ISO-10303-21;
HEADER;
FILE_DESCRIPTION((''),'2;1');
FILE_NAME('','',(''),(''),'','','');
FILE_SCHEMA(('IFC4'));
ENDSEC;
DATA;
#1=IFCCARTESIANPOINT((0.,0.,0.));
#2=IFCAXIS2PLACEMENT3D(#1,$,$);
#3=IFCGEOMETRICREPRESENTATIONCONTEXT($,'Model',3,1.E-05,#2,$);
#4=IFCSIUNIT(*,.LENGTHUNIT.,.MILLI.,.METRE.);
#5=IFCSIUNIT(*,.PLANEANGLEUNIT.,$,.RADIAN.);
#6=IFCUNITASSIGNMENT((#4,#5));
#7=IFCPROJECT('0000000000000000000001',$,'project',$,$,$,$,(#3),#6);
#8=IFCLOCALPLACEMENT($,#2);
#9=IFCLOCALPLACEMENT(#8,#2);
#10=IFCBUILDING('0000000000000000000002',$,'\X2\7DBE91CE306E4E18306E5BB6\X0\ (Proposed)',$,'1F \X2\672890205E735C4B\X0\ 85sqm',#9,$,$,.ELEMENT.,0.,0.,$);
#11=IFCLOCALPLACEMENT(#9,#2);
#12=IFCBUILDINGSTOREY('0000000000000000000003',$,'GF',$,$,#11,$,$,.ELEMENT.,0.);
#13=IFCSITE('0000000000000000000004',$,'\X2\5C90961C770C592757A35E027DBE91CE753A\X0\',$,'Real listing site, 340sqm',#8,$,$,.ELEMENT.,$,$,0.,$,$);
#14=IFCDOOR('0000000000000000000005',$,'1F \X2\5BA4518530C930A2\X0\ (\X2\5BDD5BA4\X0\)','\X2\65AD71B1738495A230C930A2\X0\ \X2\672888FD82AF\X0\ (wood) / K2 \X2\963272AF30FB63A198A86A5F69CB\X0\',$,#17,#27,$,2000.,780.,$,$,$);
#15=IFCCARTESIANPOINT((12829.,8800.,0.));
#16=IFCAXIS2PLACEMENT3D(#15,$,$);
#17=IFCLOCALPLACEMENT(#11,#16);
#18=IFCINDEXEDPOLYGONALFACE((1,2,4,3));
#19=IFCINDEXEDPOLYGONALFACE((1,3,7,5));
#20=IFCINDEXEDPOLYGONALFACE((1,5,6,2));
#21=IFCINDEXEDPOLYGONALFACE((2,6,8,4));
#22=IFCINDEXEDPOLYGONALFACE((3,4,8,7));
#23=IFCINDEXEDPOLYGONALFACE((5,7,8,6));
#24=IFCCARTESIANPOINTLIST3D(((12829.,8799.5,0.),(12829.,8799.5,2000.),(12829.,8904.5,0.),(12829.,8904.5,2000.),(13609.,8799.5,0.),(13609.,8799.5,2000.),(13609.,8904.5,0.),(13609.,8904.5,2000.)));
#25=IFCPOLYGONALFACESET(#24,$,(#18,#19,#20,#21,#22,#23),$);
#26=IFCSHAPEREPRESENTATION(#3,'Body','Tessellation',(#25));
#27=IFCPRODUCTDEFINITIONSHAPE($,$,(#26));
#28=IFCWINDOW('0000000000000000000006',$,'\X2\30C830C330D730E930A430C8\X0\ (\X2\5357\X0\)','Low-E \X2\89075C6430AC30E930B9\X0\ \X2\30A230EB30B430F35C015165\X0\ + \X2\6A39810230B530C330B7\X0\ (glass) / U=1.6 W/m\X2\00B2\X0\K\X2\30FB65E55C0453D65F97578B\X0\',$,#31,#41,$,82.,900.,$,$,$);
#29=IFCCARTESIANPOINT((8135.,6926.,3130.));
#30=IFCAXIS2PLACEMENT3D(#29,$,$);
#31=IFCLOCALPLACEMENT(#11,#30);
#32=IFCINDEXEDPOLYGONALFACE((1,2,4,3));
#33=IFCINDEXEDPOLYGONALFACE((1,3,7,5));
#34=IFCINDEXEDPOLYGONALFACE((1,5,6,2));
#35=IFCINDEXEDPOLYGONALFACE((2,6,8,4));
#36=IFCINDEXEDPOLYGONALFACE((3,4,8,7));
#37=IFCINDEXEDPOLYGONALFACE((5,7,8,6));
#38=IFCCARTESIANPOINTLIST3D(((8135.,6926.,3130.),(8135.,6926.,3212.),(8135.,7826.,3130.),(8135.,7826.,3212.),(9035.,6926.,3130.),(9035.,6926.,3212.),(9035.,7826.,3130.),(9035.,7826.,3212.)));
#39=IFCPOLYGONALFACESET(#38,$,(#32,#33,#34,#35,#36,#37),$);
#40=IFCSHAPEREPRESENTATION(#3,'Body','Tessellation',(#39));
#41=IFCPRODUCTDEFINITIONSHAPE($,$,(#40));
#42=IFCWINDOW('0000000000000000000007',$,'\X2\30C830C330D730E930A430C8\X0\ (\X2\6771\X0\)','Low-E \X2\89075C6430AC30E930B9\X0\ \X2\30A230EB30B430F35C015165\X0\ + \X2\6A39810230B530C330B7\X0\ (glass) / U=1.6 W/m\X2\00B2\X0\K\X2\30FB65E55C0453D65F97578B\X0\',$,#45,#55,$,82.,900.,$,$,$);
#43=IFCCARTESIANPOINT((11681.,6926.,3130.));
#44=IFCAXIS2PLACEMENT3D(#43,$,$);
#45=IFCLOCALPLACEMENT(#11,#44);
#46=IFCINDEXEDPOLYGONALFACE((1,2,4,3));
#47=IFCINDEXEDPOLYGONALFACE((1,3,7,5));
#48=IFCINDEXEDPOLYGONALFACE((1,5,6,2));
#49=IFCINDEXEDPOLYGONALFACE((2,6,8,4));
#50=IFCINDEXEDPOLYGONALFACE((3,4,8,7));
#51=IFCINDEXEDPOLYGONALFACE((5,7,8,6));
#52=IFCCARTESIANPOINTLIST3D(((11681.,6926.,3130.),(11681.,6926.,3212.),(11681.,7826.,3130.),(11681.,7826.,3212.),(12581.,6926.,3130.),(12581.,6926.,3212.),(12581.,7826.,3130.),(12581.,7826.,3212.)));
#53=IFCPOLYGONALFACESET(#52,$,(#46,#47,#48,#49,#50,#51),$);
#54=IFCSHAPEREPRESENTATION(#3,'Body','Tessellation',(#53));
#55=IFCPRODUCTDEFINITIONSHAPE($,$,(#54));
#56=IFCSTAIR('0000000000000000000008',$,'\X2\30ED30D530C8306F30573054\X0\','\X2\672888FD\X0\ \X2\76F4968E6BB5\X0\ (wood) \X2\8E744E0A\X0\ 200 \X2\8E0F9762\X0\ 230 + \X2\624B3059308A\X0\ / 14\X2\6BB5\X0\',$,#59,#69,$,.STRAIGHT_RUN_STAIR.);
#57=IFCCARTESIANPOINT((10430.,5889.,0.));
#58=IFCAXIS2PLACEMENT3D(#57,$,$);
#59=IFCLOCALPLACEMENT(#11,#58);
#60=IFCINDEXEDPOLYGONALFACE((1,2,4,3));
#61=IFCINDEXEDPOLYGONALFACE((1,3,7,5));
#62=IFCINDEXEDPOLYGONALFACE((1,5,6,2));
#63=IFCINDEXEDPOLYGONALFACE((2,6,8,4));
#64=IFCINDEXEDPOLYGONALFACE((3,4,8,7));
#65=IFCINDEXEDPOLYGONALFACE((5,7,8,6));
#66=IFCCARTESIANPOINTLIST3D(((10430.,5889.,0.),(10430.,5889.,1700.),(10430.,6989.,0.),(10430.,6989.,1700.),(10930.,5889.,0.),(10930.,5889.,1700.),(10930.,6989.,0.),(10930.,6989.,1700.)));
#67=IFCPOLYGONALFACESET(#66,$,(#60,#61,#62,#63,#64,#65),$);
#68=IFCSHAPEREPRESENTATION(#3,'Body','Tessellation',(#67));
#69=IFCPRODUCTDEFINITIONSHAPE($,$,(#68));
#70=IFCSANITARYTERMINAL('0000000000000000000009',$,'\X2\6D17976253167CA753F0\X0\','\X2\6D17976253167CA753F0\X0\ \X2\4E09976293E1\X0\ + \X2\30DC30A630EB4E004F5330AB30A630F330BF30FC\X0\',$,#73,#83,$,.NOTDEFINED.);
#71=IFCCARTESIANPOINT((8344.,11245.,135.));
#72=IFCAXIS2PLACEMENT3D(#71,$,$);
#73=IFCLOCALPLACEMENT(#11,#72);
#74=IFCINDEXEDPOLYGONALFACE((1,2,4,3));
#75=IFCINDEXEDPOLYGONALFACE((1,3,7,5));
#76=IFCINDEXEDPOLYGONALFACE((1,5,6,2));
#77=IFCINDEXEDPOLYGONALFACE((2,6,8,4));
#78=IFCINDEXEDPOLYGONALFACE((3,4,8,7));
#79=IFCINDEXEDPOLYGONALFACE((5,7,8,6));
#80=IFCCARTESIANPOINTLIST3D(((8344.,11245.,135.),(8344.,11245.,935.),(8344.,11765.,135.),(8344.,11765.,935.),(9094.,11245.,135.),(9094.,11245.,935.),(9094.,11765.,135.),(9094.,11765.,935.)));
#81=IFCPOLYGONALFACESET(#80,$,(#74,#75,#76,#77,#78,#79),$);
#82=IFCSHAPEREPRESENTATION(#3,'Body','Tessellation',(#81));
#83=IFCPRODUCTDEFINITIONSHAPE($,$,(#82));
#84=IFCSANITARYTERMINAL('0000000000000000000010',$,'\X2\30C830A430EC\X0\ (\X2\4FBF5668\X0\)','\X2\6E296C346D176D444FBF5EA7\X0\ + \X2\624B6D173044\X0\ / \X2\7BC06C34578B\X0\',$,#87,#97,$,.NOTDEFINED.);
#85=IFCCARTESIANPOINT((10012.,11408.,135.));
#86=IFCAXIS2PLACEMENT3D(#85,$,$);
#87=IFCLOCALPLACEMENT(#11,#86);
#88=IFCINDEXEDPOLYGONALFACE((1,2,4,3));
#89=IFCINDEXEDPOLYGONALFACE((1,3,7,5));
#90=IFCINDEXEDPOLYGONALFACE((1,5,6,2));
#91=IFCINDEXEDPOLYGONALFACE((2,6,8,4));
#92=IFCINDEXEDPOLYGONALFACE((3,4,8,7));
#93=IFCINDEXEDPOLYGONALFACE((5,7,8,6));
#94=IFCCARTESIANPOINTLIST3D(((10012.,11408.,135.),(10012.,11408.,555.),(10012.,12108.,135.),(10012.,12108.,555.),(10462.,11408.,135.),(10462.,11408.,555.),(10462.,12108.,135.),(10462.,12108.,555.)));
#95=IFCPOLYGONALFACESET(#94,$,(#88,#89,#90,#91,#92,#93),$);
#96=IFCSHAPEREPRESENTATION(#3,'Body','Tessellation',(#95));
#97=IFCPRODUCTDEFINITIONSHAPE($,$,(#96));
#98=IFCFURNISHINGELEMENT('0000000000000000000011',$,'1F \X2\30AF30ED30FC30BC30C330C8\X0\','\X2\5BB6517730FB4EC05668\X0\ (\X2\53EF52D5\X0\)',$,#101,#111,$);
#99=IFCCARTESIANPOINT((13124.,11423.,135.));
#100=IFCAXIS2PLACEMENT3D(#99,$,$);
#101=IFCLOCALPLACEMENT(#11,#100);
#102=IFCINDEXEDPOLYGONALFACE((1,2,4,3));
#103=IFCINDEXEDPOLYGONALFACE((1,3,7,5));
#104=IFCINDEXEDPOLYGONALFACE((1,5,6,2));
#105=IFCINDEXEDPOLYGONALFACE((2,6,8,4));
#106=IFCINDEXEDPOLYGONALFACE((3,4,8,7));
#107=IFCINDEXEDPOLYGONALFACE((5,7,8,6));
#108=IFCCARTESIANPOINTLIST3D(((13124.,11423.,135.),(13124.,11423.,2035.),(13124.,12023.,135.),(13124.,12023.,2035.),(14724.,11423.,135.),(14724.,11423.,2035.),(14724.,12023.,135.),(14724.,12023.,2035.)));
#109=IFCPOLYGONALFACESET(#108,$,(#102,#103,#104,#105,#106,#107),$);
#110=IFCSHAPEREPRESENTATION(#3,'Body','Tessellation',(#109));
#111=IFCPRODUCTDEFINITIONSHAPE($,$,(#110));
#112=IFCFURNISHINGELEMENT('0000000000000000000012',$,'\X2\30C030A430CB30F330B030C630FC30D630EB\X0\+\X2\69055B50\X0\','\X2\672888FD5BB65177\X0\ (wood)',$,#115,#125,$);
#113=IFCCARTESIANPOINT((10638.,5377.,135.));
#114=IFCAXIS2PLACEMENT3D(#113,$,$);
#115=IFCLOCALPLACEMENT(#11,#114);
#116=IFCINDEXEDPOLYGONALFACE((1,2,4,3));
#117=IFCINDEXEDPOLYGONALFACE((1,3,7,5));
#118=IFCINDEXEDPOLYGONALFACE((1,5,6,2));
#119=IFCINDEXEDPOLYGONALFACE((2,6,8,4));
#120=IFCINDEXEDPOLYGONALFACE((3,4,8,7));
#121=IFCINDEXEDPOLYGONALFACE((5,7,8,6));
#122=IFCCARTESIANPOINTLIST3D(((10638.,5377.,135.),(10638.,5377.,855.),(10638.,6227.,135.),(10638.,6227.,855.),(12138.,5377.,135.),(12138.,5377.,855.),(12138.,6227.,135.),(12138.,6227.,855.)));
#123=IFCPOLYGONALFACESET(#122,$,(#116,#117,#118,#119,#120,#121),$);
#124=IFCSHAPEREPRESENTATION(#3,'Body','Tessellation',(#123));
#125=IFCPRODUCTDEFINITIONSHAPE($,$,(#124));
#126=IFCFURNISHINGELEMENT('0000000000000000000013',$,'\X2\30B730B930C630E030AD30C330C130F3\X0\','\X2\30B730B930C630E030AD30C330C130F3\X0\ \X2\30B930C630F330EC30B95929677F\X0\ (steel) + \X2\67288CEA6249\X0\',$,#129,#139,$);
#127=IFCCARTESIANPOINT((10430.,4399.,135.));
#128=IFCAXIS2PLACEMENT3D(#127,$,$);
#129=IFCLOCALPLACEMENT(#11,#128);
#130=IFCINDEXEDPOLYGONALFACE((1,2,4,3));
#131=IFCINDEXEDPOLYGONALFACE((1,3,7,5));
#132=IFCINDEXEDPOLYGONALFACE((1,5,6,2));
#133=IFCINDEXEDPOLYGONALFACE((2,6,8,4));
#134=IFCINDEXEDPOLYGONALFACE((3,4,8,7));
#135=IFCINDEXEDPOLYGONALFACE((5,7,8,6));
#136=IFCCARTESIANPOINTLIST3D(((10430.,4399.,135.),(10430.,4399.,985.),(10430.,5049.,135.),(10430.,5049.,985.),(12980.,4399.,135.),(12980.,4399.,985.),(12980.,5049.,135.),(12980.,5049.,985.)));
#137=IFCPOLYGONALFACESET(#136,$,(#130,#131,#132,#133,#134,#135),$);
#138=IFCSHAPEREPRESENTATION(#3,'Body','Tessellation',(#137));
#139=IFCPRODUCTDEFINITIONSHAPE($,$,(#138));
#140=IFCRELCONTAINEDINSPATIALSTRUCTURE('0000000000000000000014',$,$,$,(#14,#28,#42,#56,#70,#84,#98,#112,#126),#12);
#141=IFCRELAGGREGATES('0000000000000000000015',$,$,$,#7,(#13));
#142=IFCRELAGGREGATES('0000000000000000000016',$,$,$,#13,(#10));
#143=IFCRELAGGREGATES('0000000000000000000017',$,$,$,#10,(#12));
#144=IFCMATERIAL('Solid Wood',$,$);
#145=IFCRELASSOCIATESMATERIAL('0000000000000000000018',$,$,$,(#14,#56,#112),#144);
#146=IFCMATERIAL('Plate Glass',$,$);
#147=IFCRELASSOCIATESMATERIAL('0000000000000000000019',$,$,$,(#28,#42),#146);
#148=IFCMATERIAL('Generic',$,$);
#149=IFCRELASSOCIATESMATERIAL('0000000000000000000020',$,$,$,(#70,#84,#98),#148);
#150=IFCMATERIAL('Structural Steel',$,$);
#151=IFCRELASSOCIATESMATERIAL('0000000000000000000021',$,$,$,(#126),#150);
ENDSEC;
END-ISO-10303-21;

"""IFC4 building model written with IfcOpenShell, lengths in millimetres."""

from ifc_helpers import new_model, si_unit, frame, frame_2d, origin, place, context, project, spatial, rectangle, extrude, material, element, save


model = new_model("IFC4")

# Units and contexts
model_context = context("Model", 3, precision=1e-05, world=origin())
ifc_project = project(units=[si_unit("LENGTHUNIT", "METRE", prefix="MILLI"), si_unit("PLANEANGLEUNIT", "RADIAN")], contexts=[model_context])

# Site, building, storey
site_placement = place(None, origin())
site = spatial("IfcSite", under=ifc_project, at=site_placement, Name="岐阜県大垣市綾野町", ObjectType="Real listing site, 340sqm", CompositionType="ELEMENT", RefElevation=0.0)
building_placement = place(site_placement, origin())
building = spatial("IfcBuilding", under=site, at=building_placement, Name="綾野の丘の家 (Proposed)", ObjectType="1F 木造平屋 85sqm", CompositionType="ELEMENT", ElevationOfRefHeight=0.0, ElevationOfTerrain=0.0)
storey_placement = place(building_placement, origin())
storey = spatial("IfcBuildingStorey", under=building, at=storey_placement, Name="GF", CompositionType="ELEMENT", Elevation=0.0)

# Shared definitions
ifc_material_1 = material(Name="Solid Wood")
ifc_material_2 = material(Name="Plate Glass")

# Door
door_placement = place(storey_placement, frame((12829.0, 8800.0, 0.0)))
element("IfcDoor", 1, at=door_placement, inside=storey, material=ifc_material_1, Name="1F 室内ドア (寝室)", Description="断熱玄関ドア 木製芯 (wood) / K2 防犯・採風機構", OverallHeight=2000.0, OverallWidth=780.0, context=model_context, shape_type="SweptSolid", body=[
    extrude(rectangle(XDim=780.0, YDim=105.0, at=frame_2d((390.0, 52.0))), frame((12829.0, 8800.0, 0.0)), (0.0, 0.0, 1.0), 2000.0),
])

# Windows
window_1_placement = place(storey_placement, frame((8135.0, 6926.0, 3130.0)))
element("IfcWindow", 2, at=window_1_placement, inside=storey, material=ifc_material_2, Name="トップライト (南)", Description="Low-E 複層ガラス アルゴン封入 + 樹脂サッシ (glass) / U=1.6 W/m²K・日射取得型", OverallHeight=82.0, OverallWidth=900.0, context=model_context, shape_type="SweptSolid", body=[
    extrude(rectangle(XDim=900.0, YDim=900.0, at=frame_2d((450.0, 450.0))), frame((8135.0, 6926.0, 3130.0)), (0.0, 0.0, 1.0), 82.0),
])
window_2_placement = place(storey_placement, frame((11681.0, 6926.0, 3130.0)))
element("IfcWindow", 3, at=window_2_placement, inside=storey, material=ifc_material_2, Name="トップライト (東)", Description="Low-E 複層ガラス アルゴン封入 + 樹脂サッシ (glass) / U=1.6 W/m²K・日射取得型", OverallHeight=82.0, OverallWidth=900.0, context=model_context, shape_type="SweptSolid", body=[
    extrude(rectangle(XDim=900.0, YDim=900.0, at=frame_2d((450.0, 450.0))), frame((11681.0, 6926.0, 3130.0)), (0.0, 0.0, 1.0), 82.0),
])

# Stair
stair_placement = place(storey_placement, frame((10430.0, 5889.0, 0.0)))
element("IfcStair", 4, at=stair_placement, inside=storey, material=ifc_material_1, Name="ロフトはしご", Description="木製 直階段 (wood) 蹴上 200 踏面 230 + 手すり / 14段", PredefinedType="STRAIGHT_RUN_STAIR", context=model_context, shape_type="SweptSolid", body=[
    extrude(rectangle(XDim=500.0, YDim=1100.0, at=frame_2d((250.0, 550.0))), frame((10430.0, 5889.0, 0.0)), (0.0, 0.0, 1.0), 1700.0),
])

# Sanitary terminals
ifc_material_3 = material(Name="Generic")
sanitary_terminal_1_placement = place(storey_placement, frame((8344.0, 11245.0, 135.0)))
element("IfcSanitaryTerminal", 5, at=sanitary_terminal_1_placement, inside=storey, material=ifc_material_3, Name="洗面化粧台", Description="洗面化粧台 三面鏡 + ボウル一体カウンター", PredefinedType="NOTDEFINED", context=model_context, shape_type="SweptSolid", body=[
    extrude(rectangle(XDim=750.0, YDim=520.0, at=frame_2d((375.0, 260.0))), frame((8344.0, 11245.0, 135.0)), (0.0, 0.0, 1.0), 800.0),
])
sanitary_terminal_2_placement = place(storey_placement, frame((10012.0, 11408.0, 135.0)))
element("IfcSanitaryTerminal", 6, at=sanitary_terminal_2_placement, inside=storey, material=ifc_material_3, Name="トイレ (便器)", Description="温水洗浄便座 + 手洗い / 節水型", PredefinedType="NOTDEFINED", context=model_context, shape_type="SweptSolid", body=[
    extrude(rectangle(XDim=450.0, YDim=700.0, at=frame_2d((225.0, 350.0))), frame((10012.0, 11408.0, 135.0)), (0.0, 0.0, 1.0), 420.0),
])

# Furnishing elements
furnishing_1_placement = place(storey_placement, frame((13124.0, 11423.0, 135.0)))
element("IfcFurnishingElement", 7, at=furnishing_1_placement, inside=storey, material=ifc_material_3, Name="1F クローゼット", Description="家具・什器 (可動)", context=model_context, shape_type="SweptSolid", body=[
    extrude(rectangle(XDim=1600.0, YDim=600.0, at=frame_2d((800.0, 300.0))), frame((13124.0, 11423.0, 135.0)), (0.0, 0.0, 1.0), 1900.0),
])
furnishing_2_placement = place(storey_placement, frame((10638.0, 5377.0, 135.0)))
element("IfcFurnishingElement", 8, at=furnishing_2_placement, inside=storey, material=ifc_material_1, Name="ダイニングテーブル+椅子", Description="木製家具 (wood)", context=model_context, shape_type="SweptSolid", body=[
    extrude(rectangle(XDim=1500.0, YDim=850.0, at=frame_2d((750.0, 425.0))), frame((10638.0, 5377.0, 135.0)), (0.0, 0.0, 1.0), 720.0),
])
ifc_material_4 = material(Name="Structural Steel")
furnishing_3_placement = place(storey_placement, frame((10430.0, 4399.0, 135.0)))
element("IfcFurnishingElement", 9, at=furnishing_3_placement, inside=storey, material=ifc_material_4, Name="システムキッチン", Description="システムキッチン ステンレス天板 (steel) + 木質扉", context=model_context, shape_type="SweptSolid", body=[
    extrude(rectangle(XDim=2550.0, YDim=650.0, at=frame_2d((1275.0, 325.0))), frame((10430.0, 4399.0, 135.0)), (0.0, 0.0, 1.0), 850.0),
])

save(model, "model.ifc")
